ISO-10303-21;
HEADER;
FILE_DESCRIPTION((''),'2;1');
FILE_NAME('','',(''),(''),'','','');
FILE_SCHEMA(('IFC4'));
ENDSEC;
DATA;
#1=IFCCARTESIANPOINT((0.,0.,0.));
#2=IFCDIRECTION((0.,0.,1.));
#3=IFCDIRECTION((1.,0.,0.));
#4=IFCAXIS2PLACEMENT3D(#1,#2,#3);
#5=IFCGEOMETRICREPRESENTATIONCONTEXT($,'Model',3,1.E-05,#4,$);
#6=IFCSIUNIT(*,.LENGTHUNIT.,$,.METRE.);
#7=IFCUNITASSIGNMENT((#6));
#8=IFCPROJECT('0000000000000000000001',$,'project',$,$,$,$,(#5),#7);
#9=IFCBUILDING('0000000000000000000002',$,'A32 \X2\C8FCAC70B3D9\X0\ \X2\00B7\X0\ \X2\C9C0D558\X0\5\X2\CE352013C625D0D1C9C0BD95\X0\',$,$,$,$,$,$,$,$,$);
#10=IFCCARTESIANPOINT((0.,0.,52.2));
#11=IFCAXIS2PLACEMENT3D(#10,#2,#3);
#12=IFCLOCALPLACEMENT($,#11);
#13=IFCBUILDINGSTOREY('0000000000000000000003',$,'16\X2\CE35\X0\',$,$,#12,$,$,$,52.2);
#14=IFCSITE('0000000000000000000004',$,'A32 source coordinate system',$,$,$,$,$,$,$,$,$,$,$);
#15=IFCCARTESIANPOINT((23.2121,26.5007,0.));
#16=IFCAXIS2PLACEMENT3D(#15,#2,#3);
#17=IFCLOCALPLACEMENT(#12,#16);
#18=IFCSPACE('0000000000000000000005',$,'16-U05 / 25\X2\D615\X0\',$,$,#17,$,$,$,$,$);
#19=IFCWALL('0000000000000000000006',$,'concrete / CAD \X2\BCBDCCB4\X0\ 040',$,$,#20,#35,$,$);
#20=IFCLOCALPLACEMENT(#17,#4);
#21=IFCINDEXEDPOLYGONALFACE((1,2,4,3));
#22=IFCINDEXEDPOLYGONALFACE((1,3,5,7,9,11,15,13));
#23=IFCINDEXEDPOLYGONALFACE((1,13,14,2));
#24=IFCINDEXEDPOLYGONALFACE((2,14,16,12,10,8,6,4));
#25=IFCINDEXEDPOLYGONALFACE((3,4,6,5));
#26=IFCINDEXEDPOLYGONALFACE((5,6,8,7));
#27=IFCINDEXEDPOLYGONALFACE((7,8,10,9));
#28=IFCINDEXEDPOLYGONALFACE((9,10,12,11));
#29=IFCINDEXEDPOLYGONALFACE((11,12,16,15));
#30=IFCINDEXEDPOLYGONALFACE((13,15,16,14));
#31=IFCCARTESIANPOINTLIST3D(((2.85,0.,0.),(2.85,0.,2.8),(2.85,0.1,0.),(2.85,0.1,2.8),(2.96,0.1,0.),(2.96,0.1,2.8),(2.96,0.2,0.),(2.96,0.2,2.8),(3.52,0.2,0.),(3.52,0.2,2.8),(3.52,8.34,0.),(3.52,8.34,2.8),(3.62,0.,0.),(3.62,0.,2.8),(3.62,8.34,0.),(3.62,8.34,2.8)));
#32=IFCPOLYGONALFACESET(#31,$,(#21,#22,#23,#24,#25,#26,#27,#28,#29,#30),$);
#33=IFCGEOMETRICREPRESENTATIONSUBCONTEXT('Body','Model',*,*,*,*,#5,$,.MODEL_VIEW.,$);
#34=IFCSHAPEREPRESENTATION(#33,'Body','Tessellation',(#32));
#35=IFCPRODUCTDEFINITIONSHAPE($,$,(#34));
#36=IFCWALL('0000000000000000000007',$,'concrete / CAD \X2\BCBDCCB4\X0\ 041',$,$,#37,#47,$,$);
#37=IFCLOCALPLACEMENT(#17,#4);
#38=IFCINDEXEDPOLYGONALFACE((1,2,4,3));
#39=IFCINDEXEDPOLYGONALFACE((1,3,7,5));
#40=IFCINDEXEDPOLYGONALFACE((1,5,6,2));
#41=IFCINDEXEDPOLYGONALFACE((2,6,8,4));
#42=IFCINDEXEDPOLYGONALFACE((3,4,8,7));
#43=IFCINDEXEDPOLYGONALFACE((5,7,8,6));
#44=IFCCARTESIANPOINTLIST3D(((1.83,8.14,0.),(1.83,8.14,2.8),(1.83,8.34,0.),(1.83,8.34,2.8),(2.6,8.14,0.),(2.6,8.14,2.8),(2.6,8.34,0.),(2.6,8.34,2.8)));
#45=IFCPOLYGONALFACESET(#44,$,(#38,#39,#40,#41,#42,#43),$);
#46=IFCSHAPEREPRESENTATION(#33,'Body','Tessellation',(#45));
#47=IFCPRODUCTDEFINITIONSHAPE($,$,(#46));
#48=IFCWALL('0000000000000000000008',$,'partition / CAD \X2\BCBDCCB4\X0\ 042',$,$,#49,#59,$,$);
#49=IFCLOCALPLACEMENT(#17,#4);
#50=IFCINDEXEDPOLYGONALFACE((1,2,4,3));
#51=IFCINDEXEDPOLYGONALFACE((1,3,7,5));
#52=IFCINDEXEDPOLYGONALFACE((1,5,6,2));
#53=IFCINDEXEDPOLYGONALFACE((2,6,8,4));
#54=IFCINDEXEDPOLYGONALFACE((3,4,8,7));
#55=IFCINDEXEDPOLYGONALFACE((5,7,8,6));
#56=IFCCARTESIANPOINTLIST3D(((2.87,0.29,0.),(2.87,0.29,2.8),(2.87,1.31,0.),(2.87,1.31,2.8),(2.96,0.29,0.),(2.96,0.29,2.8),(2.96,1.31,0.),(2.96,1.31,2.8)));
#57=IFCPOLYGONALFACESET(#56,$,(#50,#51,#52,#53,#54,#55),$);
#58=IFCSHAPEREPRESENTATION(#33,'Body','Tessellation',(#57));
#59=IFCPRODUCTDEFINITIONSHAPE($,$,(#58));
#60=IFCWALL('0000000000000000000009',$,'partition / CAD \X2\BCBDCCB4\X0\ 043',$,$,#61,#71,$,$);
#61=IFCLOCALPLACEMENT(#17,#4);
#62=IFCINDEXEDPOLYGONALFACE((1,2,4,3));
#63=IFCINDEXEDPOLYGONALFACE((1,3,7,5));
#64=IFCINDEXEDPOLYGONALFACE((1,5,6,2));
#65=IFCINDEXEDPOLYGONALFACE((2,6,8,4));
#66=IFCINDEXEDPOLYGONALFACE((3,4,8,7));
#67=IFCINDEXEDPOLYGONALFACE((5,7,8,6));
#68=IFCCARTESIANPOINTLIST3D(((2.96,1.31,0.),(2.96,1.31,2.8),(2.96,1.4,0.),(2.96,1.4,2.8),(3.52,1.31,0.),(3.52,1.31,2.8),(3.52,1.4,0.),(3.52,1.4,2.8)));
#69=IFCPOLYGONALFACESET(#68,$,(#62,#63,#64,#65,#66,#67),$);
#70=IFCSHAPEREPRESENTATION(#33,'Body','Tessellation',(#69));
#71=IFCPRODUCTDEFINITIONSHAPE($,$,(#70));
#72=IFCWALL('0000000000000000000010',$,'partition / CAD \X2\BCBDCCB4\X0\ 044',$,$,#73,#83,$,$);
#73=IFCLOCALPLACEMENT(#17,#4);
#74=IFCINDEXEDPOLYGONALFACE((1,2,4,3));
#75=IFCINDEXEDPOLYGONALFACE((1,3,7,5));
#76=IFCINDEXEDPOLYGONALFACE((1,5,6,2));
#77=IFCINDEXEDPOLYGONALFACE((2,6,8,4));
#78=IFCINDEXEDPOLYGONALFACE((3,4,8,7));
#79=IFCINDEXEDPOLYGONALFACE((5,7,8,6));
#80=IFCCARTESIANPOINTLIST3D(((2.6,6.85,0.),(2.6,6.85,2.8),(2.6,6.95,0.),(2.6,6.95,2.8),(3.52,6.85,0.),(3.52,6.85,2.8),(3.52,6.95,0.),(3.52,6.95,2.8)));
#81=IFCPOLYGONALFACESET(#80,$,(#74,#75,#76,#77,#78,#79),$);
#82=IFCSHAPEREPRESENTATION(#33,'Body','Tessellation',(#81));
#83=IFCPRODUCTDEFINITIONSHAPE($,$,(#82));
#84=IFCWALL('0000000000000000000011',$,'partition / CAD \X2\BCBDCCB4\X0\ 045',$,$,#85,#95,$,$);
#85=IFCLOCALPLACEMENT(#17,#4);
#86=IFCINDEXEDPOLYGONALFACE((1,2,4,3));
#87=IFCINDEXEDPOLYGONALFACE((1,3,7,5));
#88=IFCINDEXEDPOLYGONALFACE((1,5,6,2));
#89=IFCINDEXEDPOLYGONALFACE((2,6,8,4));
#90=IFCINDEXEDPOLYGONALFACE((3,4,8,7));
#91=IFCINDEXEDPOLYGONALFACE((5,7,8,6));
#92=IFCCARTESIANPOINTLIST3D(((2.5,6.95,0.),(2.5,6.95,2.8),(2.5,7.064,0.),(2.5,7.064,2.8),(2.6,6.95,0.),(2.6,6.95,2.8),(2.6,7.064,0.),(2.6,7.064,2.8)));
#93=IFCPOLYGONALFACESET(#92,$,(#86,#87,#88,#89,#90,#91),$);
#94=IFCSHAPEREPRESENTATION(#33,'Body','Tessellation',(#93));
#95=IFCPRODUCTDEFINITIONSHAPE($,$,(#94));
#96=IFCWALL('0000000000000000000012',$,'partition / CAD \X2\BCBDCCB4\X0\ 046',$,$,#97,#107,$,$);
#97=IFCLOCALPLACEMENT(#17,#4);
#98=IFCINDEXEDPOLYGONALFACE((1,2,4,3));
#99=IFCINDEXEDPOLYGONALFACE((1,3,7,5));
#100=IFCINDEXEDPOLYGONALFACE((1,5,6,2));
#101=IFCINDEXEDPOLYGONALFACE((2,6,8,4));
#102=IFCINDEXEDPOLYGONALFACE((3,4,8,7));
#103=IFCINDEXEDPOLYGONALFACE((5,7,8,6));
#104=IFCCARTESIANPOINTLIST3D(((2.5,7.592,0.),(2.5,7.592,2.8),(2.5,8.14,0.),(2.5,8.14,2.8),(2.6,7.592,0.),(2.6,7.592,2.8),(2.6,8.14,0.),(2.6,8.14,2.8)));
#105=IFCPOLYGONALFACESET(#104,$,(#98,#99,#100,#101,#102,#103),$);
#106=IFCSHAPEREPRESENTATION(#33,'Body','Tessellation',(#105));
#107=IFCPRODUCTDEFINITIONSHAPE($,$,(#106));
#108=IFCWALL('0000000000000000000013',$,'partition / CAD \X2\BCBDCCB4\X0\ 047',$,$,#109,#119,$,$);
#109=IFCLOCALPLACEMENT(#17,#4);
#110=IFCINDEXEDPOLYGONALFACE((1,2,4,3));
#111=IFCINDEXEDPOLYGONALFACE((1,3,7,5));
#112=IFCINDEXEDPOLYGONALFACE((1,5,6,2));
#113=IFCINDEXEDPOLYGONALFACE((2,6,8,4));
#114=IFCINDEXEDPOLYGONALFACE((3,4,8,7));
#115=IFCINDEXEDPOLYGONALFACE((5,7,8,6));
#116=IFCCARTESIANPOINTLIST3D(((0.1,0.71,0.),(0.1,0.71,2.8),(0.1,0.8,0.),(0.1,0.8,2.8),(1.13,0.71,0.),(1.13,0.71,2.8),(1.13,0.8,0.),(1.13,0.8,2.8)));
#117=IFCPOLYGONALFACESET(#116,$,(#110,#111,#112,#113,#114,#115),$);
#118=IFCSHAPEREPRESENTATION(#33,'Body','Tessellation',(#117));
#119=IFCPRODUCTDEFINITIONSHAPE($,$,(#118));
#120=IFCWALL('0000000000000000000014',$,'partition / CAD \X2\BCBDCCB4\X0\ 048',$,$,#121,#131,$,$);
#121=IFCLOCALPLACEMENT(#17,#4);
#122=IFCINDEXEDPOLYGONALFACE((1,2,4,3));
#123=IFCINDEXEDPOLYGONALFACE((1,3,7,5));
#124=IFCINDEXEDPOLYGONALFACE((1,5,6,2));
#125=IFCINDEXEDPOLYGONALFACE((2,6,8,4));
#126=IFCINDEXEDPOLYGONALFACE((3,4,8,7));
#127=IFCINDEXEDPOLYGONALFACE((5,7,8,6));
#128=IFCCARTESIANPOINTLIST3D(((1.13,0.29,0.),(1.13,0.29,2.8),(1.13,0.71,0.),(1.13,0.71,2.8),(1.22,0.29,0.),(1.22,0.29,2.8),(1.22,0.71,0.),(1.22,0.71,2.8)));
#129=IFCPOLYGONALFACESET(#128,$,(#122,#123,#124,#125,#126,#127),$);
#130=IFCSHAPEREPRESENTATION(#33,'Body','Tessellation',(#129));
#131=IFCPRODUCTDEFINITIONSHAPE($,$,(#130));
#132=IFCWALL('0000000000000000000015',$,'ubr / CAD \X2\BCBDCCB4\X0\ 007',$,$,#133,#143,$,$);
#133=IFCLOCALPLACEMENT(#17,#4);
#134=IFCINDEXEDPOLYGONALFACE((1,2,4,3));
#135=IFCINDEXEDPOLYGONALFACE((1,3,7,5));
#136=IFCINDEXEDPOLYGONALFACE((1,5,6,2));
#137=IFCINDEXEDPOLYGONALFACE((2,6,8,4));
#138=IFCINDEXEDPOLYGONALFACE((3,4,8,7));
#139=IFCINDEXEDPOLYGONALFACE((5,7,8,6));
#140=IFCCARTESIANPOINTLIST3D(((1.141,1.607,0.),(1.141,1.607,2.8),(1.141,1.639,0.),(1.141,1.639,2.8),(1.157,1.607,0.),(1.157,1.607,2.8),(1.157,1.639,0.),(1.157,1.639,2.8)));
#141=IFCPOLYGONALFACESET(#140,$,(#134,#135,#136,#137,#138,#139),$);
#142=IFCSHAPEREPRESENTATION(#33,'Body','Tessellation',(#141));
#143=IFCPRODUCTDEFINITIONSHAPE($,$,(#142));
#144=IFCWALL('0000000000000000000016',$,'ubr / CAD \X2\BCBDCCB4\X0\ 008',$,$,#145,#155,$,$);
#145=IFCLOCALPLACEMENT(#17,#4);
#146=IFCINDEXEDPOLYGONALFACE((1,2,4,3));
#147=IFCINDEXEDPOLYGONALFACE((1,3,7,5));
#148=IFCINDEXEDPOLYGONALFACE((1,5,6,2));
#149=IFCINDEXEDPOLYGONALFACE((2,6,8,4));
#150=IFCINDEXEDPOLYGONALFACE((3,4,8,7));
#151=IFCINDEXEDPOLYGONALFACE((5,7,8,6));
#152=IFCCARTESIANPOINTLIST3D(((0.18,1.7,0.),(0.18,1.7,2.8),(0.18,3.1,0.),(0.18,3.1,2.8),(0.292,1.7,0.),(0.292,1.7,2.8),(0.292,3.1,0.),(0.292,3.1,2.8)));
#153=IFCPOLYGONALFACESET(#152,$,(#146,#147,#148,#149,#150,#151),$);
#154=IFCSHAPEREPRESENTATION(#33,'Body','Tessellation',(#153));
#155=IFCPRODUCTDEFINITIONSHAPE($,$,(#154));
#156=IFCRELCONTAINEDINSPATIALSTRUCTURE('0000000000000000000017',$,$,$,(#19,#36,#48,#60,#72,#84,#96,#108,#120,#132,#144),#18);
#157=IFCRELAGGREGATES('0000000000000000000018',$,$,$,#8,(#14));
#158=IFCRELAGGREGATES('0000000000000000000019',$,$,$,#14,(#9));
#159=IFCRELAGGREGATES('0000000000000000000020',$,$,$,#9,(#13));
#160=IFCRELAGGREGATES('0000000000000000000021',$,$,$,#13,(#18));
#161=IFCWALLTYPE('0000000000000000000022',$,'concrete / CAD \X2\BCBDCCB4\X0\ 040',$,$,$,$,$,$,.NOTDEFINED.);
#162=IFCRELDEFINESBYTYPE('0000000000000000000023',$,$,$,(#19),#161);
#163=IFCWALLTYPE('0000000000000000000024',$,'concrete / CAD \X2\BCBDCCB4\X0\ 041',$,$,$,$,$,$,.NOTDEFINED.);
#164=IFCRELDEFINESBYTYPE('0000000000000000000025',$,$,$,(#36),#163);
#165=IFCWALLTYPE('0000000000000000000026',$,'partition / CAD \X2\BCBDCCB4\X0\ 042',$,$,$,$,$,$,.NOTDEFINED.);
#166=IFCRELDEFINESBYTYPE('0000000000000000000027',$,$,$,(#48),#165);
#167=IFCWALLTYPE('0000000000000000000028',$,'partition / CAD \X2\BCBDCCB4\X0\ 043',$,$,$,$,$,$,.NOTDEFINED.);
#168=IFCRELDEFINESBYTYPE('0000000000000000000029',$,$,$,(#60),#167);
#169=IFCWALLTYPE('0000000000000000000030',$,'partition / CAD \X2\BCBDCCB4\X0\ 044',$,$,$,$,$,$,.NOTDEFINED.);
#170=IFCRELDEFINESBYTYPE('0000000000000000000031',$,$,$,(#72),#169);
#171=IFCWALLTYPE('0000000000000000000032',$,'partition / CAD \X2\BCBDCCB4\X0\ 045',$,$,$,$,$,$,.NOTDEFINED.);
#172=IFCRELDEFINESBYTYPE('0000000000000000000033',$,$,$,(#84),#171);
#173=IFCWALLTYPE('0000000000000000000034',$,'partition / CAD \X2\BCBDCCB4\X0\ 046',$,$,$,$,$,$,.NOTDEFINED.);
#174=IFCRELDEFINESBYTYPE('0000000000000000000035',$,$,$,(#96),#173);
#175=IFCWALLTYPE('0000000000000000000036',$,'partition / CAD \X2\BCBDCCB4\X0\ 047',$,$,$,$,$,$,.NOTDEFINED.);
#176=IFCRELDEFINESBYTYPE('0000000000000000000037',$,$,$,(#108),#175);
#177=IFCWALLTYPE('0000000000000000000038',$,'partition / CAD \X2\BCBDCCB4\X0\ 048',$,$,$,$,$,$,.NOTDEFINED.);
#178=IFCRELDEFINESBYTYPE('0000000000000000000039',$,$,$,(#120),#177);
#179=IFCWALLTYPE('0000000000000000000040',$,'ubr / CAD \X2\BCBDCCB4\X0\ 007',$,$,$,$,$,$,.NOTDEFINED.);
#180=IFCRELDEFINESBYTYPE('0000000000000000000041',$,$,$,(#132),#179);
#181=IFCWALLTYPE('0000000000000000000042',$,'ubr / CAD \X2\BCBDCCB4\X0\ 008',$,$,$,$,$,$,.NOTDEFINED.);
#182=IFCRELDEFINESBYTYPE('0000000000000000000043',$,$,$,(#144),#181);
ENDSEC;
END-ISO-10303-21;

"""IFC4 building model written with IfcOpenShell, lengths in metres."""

from ifc_helpers import new_model, si_unit, frame, origin, origin_with_axes, place, context, subcontext, project, spatial, polyline, outline, extrude, source, transform, mapped, type_object, type_shapes, element, save


model = new_model("IFC4")

# Units and contexts
model_context = context("Model", 3, precision=1e-05, world=origin_with_axes())
body_context = subcontext(model_context, "Body", "Model", "MODEL_VIEW")
ifc_project = project(units=[si_unit("LENGTHUNIT", "METRE")], contexts=[model_context])

# Site, building, storey, space
site = spatial("IfcSite", under=ifc_project, Name="A32 source coordinate system")
building = spatial("IfcBuilding", under=site, Name="A32 주거동 · 지하5층–옥탑지붕")
storey_placement = place(None, frame((0.0, 0.0, 52.2), z_axis=(0.0, 0.0, 1.0), x_axis=(1.0, 0.0, 0.0)))
storey = spatial("IfcBuildingStorey", under=building, at=storey_placement, Name="16층", Elevation=52.2)
space_1_placement = place(storey_placement, frame((23.2121, 26.5007, 0.0), z_axis=(0.0, 0.0, 1.0), x_axis=(1.0, 0.0, 0.0)))
space_1 = spatial("IfcSpace", under=storey, at=space_1_placement, Name="16-U05 / 25형")

# Walls
wall_type_1 = type_object("IfcWallType", Name="concrete / CAD 벽체 040", PredefinedType="NOTDEFINED")
shared_shape_1 = source(origin(), body_context, "Body", "SweptSolid", [
    extrude(outline(polyline([(3.62, 8.34), (3.62, 0.0), (2.85, 0.0), (2.85, 0.1), (2.96, 0.1), (2.96, 0.2), (3.52, 0.2), (3.52, 8.34), (3.62, 8.34)])), origin(), (0.0, 0.0, 1.0), 2.8),
])
type_shapes(wall_type_1, [shared_shape_1])
wall_1_placement = place(space_1_placement, origin_with_axes())
element("IfcWall", 1, at=wall_1_placement, inside=space_1, type_object=wall_type_1, Name="concrete / CAD 벽체 040", context=body_context, shape_type="MappedRepresentation", body=[
    mapped(shared_shape_1, transform((0.0, 0.0, 0.0), scale=1.0)),
])
wall_type_2 = type_object("IfcWallType", Name="concrete / CAD 벽체 041", PredefinedType="NOTDEFINED")
shared_shape_2 = source(origin(), body_context, "Body", "SweptSolid", [
    extrude(outline(polyline([(2.6, 8.14), (1.83, 8.14), (1.83, 8.34), (2.6, 8.34), (2.6, 8.14)])), origin(), (0.0, 0.0, 1.0), 2.8),
])
type_shapes(wall_type_2, [shared_shape_2])
wall_2_placement = place(space_1_placement, origin_with_axes())
element("IfcWall", 2, at=wall_2_placement, inside=space_1, type_object=wall_type_2, Name="concrete / CAD 벽체 041", context=body_context, shape_type="MappedRepresentation", body=[
    mapped(shared_shape_2, transform((0.0, 0.0, 0.0), scale=1.0)),
])
wall_type_3 = type_object("IfcWallType", Name="partition / CAD 벽체 042", PredefinedType="NOTDEFINED")
shared_shape_3 = source(origin(), body_context, "Body", "SweptSolid", [
    extrude(outline(polyline([(2.87, 1.31), (2.96, 1.31), (2.96, 0.29), (2.87, 0.29), (2.87, 1.31)])), origin(), (0.0, 0.0, 1.0), 2.8),
])
type_shapes(wall_type_3, [shared_shape_3])
wall_3_placement = place(space_1_placement, origin_with_axes())
element("IfcWall", 3, at=wall_3_placement, inside=space_1, type_object=wall_type_3, Name="partition / CAD 벽체 042", context=body_context, shape_type="MappedRepresentation", body=[
    mapped(shared_shape_3, transform((0.0, 0.0, 0.0), scale=1.0)),
])
wall_type_4 = type_object("IfcWallType", Name="partition / CAD 벽체 043", PredefinedType="NOTDEFINED")
shared_shape_4 = source(origin(), body_context, "Body", "SweptSolid", [
    extrude(outline(polyline([(3.52, 1.4), (3.52, 1.31), (2.96, 1.31), (2.96, 1.4), (3.52, 1.4)])), origin(), (0.0, 0.0, 1.0), 2.8),
])
type_shapes(wall_type_4, [shared_shape_4])
wall_4_placement = place(space_1_placement, origin_with_axes())
element("IfcWall", 4, at=wall_4_placement, inside=space_1, type_object=wall_type_4, Name="partition / CAD 벽체 043", context=body_context, shape_type="MappedRepresentation", body=[
    mapped(shared_shape_4, transform((0.0, 0.0, 0.0), scale=1.0)),
])
wall_type_5 = type_object("IfcWallType", Name="partition / CAD 벽체 044", PredefinedType="NOTDEFINED")
shared_shape_5 = source(origin(), body_context, "Body", "SweptSolid", [
    extrude(outline(polyline([(3.52, 6.95), (3.52, 6.85), (2.6, 6.85), (2.6, 6.95), (3.52, 6.95)])), origin(), (0.0, 0.0, 1.0), 2.8),
])
type_shapes(wall_type_5, [shared_shape_5])
wall_5_placement = place(space_1_placement, origin_with_axes())
element("IfcWall", 5, at=wall_5_placement, inside=space_1, type_object=wall_type_5, Name="partition / CAD 벽체 044", context=body_context, shape_type="MappedRepresentation", body=[
    mapped(shared_shape_5, transform((0.0, 0.0, 0.0), scale=1.0)),
])
wall_type_6 = type_object("IfcWallType", Name="partition / CAD 벽체 045", PredefinedType="NOTDEFINED")
shared_shape_6 = source(origin(), body_context, "Body", "SweptSolid", [
    extrude(outline(polyline([(2.5, 7.064), (2.6, 7.064), (2.6, 6.95), (2.5, 6.95), (2.5, 7.064)])), origin(), (0.0, 0.0, 1.0), 2.8),
])
type_shapes(wall_type_6, [shared_shape_6])
wall_6_placement = place(space_1_placement, origin_with_axes())
element("IfcWall", 6, at=wall_6_placement, inside=space_1, type_object=wall_type_6, Name="partition / CAD 벽체 045", context=body_context, shape_type="MappedRepresentation", body=[
    mapped(shared_shape_6, transform((0.0, 0.0, 0.0), scale=1.0)),
])
wall_type_7 = type_object("IfcWallType", Name="partition / CAD 벽체 046", PredefinedType="NOTDEFINED")
shared_shape_7 = source(origin(), body_context, "Body", "SweptSolid", [
    extrude(outline(polyline([(2.6, 7.592), (2.5, 7.592), (2.5, 8.14), (2.6, 8.14), (2.6, 7.592)])), origin(), (0.0, 0.0, 1.0), 2.8),
])
type_shapes(wall_type_7, [shared_shape_7])
wall_7_placement = place(space_1_placement, origin_with_axes())
element("IfcWall", 7, at=wall_7_placement, inside=space_1, type_object=wall_type_7, Name="partition / CAD 벽체 046", context=body_context, shape_type="MappedRepresentation", body=[
    mapped(shared_shape_7, transform((0.0, 0.0, 0.0), scale=1.0)),
])
wall_type_8 = type_object("IfcWallType", Name="partition / CAD 벽체 047", PredefinedType="NOTDEFINED")
shared_shape_8 = source(origin(), body_context, "Body", "SweptSolid", [
    extrude(outline(polyline([(1.13, 0.71), (0.1, 0.71), (0.1, 0.8), (1.13, 0.8), (1.13, 0.71)])), origin(), (0.0, 0.0, 1.0), 2.8),
])
type_shapes(wall_type_8, [shared_shape_8])
wall_8_placement = place(space_1_placement, origin_with_axes())
element("IfcWall", 8, at=wall_8_placement, inside=space_1, type_object=wall_type_8, Name="partition / CAD 벽체 047", context=body_context, shape_type="MappedRepresentation", body=[
    mapped(shared_shape_8, transform((0.0, 0.0, 0.0), scale=1.0)),
])
wall_type_9 = type_object("IfcWallType", Name="partition / CAD 벽체 048", PredefinedType="NOTDEFINED")
shared_shape_9 = source(origin(), body_context, "Body", "SweptSolid", [
    extrude(outline(polyline([(1.22, 0.29), (1.13, 0.29), (1.13, 0.71), (1.22, 0.71), (1.22, 0.29)])), origin(), (0.0, 0.0, 1.0), 2.8),
])
type_shapes(wall_type_9, [shared_shape_9])
wall_9_placement = place(space_1_placement, origin_with_axes())
element("IfcWall", 9, at=wall_9_placement, inside=space_1, type_object=wall_type_9, Name="partition / CAD 벽체 048", context=body_context, shape_type="MappedRepresentation", body=[
    mapped(shared_shape_9, transform((0.0, 0.0, 0.0), scale=1.0)),
])
wall_type_10 = type_object("IfcWallType", Name="ubr / CAD 벽체 007", PredefinedType="NOTDEFINED")
shared_shape_10 = source(origin(), body_context, "Body", "SweptSolid", [
    extrude(outline(polyline([(1.157, 1.607), (1.141, 1.607), (1.141, 1.639), (1.157, 1.639), (1.157, 1.607)])), origin(), (0.0, 0.0, 1.0), 2.8),
])
type_shapes(wall_type_10, [shared_shape_10])
wall_10_placement = place(space_1_placement, origin_with_axes())
element("IfcWall", 10, at=wall_10_placement, inside=space_1, type_object=wall_type_10, Name="ubr / CAD 벽체 007", context=body_context, shape_type="MappedRepresentation", body=[
    mapped(shared_shape_10, transform((0.0, 0.0, 0.0), scale=1.0)),
])
wall_type_11 = type_object("IfcWallType", Name="ubr / CAD 벽체 008", PredefinedType="NOTDEFINED")
shared_shape_11 = source(origin(), body_context, "Body", "SweptSolid", [
    extrude(outline(polyline([(0.292, 1.7), (0.18, 1.7), (0.18, 3.1), (0.292, 3.1), (0.292, 1.7)])), origin(), (0.0, 0.0, 1.0), 2.8),
])
type_shapes(wall_type_11, [shared_shape_11])
wall_11_placement = place(space_1_placement, origin_with_axes())
element("IfcWall", 11, at=wall_11_placement, inside=space_1, type_object=wall_type_11, Name="ubr / CAD 벽체 008", context=body_context, shape_type="MappedRepresentation", body=[
    mapped(shared_shape_11, transform((0.0, 0.0, 0.0), scale=1.0)),
])

save(model, "model.ifc")
